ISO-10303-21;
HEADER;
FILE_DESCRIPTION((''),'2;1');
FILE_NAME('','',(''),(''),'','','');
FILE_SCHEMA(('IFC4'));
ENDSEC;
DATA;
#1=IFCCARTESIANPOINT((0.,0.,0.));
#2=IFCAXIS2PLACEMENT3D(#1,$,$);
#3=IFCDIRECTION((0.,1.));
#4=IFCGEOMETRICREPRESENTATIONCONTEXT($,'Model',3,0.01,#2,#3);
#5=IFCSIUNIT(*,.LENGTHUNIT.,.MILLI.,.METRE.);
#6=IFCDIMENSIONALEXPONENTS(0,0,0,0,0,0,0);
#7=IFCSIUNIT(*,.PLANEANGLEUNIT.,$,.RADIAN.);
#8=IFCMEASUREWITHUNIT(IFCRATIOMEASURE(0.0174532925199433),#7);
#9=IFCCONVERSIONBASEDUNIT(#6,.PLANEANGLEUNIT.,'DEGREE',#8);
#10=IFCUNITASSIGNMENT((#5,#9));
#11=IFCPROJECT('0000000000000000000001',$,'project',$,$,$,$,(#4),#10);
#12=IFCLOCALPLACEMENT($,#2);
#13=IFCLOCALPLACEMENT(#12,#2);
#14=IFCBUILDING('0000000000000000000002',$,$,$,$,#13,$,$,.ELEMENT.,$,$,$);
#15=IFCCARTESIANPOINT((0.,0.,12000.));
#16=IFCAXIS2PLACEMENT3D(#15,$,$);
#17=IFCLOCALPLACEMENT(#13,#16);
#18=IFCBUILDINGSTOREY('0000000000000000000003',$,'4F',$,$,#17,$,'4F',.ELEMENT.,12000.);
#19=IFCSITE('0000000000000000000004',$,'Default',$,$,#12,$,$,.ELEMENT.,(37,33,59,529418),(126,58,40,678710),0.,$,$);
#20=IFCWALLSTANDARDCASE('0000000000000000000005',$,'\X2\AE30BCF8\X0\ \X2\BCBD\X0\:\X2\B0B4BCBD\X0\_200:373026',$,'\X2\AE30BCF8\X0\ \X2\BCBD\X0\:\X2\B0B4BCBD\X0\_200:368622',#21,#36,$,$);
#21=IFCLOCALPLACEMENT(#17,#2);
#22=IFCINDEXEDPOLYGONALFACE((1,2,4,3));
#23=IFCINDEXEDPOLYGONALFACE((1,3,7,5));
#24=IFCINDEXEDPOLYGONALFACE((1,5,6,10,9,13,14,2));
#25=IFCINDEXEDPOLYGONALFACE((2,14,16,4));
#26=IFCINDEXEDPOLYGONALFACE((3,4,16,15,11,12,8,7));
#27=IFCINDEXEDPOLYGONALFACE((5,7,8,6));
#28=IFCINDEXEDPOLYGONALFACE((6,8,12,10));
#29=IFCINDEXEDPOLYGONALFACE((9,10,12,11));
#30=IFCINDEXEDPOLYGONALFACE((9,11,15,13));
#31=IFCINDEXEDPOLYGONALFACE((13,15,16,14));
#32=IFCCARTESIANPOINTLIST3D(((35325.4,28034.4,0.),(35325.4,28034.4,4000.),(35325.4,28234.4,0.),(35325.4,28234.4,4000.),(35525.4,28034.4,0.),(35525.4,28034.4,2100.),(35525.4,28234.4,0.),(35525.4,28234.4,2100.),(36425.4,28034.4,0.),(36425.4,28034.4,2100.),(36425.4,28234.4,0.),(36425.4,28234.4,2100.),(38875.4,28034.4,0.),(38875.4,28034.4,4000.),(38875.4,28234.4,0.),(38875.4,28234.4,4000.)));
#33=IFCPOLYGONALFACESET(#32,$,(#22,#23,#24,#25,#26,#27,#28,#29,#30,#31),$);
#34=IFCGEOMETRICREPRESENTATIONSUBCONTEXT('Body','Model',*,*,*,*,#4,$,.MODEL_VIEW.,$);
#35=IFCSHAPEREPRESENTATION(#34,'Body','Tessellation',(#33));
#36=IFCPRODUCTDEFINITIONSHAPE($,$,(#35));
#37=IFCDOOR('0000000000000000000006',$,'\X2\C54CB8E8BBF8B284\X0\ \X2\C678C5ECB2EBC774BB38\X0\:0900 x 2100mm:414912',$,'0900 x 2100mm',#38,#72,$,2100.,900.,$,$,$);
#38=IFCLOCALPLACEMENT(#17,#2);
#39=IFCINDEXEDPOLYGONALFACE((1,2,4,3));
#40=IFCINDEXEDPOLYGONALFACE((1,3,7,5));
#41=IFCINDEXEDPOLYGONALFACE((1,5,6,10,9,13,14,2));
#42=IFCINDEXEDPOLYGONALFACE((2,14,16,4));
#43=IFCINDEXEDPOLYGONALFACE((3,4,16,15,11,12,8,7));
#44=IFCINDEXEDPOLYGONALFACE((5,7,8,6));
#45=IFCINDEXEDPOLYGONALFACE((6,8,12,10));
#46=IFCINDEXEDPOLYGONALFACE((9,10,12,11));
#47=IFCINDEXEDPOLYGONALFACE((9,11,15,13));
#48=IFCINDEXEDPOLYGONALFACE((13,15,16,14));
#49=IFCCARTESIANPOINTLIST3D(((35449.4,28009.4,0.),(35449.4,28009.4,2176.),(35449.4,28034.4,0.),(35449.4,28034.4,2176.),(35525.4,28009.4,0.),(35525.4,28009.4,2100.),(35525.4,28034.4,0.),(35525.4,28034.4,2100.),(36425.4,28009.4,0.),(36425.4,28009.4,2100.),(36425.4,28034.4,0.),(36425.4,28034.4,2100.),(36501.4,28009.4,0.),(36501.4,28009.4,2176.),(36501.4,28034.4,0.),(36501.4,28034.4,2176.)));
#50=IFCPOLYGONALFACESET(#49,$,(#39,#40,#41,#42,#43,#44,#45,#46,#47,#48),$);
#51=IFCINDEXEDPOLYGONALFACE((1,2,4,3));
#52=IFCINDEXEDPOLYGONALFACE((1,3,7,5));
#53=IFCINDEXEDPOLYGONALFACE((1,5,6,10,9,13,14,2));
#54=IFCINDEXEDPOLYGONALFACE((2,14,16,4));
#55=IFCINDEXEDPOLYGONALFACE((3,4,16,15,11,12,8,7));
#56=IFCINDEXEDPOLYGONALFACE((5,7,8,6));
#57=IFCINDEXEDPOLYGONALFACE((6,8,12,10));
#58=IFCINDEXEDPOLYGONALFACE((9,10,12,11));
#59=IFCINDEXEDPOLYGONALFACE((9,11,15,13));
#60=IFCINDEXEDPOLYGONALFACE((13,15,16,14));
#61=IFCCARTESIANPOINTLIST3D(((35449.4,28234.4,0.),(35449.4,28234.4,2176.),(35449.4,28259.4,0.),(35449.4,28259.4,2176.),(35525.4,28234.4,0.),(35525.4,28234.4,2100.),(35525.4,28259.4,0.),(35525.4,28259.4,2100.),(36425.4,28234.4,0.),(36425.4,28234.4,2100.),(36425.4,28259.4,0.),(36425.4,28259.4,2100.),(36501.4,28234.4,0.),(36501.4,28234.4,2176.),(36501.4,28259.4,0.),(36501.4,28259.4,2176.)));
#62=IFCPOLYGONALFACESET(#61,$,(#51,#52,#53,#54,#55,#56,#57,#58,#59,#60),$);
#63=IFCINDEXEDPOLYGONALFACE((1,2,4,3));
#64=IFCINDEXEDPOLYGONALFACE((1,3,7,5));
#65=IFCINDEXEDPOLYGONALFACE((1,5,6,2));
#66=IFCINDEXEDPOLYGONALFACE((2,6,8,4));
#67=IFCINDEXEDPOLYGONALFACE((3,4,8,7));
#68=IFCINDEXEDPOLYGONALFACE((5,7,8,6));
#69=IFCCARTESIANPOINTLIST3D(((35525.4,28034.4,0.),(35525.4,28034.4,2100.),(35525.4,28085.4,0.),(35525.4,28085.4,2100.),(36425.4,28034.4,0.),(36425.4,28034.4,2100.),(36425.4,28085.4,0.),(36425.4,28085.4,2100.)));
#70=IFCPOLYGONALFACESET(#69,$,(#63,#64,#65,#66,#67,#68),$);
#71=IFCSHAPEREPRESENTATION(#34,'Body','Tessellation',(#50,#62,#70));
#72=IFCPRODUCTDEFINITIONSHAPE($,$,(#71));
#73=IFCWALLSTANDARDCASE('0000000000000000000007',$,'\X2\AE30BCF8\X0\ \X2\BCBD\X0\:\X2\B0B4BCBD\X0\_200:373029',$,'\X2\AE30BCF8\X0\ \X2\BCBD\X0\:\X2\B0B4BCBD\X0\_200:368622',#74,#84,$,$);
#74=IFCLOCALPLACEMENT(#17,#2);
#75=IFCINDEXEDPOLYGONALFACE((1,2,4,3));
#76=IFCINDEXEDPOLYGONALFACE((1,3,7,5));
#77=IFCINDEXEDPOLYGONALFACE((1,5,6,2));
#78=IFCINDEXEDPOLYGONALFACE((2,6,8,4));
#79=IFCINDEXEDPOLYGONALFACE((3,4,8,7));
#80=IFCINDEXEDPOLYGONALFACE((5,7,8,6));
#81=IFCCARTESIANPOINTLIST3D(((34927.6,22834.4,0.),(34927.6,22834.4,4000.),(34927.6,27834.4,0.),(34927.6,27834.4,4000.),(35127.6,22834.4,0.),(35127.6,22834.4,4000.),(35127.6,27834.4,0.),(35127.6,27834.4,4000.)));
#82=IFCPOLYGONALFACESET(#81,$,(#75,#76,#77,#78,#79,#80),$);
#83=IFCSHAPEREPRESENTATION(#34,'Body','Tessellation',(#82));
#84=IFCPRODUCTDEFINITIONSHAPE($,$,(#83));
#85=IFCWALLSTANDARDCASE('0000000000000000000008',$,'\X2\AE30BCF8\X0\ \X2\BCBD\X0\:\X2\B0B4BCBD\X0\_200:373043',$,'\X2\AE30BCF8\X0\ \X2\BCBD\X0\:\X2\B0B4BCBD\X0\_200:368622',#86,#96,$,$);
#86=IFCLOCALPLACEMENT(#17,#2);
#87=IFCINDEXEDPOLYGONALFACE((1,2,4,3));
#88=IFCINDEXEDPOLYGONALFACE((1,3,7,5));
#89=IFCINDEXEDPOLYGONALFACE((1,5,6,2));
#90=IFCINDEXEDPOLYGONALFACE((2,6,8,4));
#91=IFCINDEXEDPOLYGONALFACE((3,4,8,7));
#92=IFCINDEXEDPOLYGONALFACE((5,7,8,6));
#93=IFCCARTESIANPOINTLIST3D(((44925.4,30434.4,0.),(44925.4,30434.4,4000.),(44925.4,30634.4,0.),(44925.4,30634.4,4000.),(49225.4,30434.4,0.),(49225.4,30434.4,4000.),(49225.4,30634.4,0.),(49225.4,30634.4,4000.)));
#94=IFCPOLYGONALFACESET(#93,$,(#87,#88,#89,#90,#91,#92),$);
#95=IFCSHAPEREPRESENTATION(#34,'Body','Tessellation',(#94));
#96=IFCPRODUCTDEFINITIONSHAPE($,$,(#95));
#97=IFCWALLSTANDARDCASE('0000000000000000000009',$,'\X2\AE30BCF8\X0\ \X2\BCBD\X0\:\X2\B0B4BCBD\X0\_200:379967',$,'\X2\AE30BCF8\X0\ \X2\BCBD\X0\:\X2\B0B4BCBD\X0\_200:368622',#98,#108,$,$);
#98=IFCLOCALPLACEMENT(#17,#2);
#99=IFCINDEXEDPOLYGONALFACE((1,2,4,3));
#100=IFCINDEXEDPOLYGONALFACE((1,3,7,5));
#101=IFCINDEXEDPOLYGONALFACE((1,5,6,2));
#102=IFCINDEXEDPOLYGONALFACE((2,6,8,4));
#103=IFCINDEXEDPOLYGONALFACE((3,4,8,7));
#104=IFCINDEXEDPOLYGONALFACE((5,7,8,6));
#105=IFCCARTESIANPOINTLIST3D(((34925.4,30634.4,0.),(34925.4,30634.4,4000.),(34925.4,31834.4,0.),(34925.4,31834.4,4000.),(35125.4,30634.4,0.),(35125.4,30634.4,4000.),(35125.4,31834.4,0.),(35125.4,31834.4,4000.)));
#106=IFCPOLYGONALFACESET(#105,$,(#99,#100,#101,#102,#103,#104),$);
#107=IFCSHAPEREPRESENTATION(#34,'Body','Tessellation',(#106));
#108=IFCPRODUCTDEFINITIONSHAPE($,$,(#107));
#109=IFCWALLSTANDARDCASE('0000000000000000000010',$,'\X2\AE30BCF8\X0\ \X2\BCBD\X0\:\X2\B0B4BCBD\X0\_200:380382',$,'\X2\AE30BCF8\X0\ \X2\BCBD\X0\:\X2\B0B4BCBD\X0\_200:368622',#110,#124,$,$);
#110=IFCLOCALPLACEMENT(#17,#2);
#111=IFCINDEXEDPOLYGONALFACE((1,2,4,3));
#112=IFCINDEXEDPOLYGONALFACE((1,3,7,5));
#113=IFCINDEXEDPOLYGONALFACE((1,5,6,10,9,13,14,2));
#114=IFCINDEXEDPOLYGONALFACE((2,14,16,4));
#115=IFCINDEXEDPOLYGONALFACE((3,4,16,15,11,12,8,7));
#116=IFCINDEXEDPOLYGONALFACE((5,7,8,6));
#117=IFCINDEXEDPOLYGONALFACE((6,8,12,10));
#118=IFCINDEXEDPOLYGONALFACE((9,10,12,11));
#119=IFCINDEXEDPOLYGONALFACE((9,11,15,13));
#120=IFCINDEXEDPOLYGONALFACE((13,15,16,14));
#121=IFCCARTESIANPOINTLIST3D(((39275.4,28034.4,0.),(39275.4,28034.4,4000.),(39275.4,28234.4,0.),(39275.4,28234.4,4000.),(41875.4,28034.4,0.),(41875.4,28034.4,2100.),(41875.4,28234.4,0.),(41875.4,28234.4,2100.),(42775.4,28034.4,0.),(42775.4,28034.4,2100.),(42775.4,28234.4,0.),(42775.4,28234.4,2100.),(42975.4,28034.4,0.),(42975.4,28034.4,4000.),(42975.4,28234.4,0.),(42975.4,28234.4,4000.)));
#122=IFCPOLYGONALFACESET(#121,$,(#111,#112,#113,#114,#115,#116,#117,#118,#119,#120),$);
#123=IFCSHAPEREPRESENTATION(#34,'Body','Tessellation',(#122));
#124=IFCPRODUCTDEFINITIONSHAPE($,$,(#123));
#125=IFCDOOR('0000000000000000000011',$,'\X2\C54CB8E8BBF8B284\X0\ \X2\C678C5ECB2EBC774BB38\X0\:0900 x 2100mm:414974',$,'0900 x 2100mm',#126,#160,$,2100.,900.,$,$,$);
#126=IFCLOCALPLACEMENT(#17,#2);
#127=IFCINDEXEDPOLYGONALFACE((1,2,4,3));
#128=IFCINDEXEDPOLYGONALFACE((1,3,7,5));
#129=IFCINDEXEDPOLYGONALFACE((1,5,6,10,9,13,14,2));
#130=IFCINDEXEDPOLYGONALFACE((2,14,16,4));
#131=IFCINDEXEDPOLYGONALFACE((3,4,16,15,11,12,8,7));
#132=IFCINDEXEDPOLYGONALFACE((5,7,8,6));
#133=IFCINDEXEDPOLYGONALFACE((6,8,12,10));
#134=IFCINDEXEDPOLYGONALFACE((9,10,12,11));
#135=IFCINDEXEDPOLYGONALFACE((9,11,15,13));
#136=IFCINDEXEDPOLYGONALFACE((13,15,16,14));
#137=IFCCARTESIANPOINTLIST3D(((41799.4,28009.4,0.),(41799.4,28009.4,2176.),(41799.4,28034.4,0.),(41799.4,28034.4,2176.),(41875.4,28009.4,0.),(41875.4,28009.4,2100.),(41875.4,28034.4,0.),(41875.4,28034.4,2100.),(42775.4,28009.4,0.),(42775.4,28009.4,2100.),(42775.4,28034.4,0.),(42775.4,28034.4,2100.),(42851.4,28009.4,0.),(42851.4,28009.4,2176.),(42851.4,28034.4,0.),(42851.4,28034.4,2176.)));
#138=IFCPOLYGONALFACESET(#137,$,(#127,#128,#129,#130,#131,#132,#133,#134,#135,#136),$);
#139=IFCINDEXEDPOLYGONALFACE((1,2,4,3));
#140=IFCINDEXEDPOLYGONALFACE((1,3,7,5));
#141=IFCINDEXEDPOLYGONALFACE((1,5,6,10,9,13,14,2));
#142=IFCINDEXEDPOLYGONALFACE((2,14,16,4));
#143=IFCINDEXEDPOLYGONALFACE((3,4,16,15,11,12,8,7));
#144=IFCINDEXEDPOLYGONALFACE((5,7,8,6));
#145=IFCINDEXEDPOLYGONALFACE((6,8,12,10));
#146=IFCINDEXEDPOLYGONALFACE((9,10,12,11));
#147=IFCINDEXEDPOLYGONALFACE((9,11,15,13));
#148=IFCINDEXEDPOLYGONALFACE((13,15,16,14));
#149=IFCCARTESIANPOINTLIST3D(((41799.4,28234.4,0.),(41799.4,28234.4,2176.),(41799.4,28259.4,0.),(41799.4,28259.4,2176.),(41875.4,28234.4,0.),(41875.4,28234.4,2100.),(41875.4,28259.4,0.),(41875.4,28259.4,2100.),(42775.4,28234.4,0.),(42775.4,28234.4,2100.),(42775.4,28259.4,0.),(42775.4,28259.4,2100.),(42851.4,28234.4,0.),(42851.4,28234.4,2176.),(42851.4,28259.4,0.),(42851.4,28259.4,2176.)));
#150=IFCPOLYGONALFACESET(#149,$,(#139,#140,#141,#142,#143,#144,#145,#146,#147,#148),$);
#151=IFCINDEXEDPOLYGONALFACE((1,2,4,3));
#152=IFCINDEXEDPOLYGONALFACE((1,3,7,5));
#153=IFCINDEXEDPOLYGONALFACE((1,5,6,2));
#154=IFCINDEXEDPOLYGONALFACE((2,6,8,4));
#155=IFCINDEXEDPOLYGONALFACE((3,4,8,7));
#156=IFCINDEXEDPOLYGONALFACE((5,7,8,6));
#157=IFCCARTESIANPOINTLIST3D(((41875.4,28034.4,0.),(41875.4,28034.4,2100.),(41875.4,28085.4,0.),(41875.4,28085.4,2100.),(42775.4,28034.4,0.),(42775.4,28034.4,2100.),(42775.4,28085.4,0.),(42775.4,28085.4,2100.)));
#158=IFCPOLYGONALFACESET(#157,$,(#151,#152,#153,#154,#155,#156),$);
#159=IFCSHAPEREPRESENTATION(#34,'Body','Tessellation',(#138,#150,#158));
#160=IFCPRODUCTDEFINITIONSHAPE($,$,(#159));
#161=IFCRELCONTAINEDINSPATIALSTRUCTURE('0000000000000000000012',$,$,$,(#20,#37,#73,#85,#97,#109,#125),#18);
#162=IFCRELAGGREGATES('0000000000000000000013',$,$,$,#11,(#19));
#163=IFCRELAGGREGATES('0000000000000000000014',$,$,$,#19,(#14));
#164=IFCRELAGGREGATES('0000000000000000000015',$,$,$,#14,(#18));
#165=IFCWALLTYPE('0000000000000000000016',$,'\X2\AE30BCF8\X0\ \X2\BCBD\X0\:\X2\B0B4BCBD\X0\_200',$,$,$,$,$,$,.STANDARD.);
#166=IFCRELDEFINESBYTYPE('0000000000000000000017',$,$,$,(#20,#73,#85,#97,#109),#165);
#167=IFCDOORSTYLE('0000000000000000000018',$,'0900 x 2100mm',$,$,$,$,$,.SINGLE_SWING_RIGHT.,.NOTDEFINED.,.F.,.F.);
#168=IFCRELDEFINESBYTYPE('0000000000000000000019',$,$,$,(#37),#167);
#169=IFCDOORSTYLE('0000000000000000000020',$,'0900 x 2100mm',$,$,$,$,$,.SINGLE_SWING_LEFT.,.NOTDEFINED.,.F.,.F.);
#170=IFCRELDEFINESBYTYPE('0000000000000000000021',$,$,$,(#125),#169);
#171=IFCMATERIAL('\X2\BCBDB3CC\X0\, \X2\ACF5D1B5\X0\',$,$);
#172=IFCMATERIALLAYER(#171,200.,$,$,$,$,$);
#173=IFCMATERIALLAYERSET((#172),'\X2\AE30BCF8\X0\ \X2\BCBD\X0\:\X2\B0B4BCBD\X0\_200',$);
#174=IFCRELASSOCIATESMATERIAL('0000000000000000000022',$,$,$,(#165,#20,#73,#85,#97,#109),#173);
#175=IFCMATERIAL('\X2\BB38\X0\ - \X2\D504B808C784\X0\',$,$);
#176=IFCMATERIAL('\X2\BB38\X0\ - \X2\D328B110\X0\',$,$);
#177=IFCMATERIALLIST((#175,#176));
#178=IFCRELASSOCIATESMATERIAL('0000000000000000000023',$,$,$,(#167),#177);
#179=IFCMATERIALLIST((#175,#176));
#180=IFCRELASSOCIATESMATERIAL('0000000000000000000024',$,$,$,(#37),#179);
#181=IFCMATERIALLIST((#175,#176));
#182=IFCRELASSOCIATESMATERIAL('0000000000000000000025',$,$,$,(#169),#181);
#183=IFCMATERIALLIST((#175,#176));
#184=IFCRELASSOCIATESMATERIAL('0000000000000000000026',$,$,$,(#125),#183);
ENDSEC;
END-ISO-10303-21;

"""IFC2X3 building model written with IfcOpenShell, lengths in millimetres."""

from ifc_helpers import new_model, entity, si_unit, converted_unit, direction, frame, frame_2d, origin, place, context, subcontext, project, spatial, polyline, rectangle, outline, extrude, source, transform, mapped, material, material_list, layer, layer_set, layer_usage, type_object, type_shapes, element, fill, save


model = new_model("IFC2X3")

# Units and contexts
model_context = context("Model", 3, precision=0.01, world=origin(), true_north=direction((0.0, 1.0)))
body_context = subcontext(model_context, "Body", "Model", "MODEL_VIEW")
ifc_project = project(units=[si_unit("LENGTHUNIT", "METRE", prefix="MILLI"), converted_unit("PLANEANGLEUNIT", "DEGREE", entity("IfcRatioMeasure", 0.0174532925199433), si_unit("PLANEANGLEUNIT", "RADIAN"), dimensions=[0, 0, 0, 0, 0, 0, 0])], contexts=[model_context])

# Site, building, storey
site_placement = place(None, origin())
site = spatial("IfcSite", under=ifc_project, at=site_placement, Name="Default", CompositionType="ELEMENT", RefLatitude=(37, 33, 59, 529418), RefLongitude=(126, 58, 40, 678710), RefElevation=0.0)
building_placement = place(site_placement, origin())
building = spatial("IfcBuilding", under=site, at=building_placement, CompositionType="ELEMENT")
storey_placement = place(building_placement, frame((0.0, 0.0, 12000.0)))
storey = spatial("IfcBuildingStorey", under=building, at=storey_placement, Name="4F", LongName="4F", CompositionType="ELEMENT", Elevation=12000.0)

# Wall, opening, door
ifc_material_1 = material(Name="벽돌, 공통")
ifc_layer_1 = layer(ifc_material_1, 200.0)
ifc_layer_set_1 = layer_set([ifc_layer_1], Name="기본 벽:내벽_200")
ifc_layer_usage_1 = layer_usage(ifc_layer_set_1, "AXIS2", "NEGATIVE", 100.0)
wall_type_1 = type_object("IfcWallType", Name="기본 벽:내벽_200", PredefinedType="STANDARD", material=ifc_layer_set_1)
wall_1_placement = place(storey_placement, frame((35325.4, 28134.4, 0.0)))
wall_1 = element("IfcWallStandardCase", 1, at=wall_1_placement, inside=storey, type_object=wall_type_1, material=ifc_layer_usage_1, Name="기본 벽:내벽_200:373026", ObjectType="기본 벽:내벽_200:368622", context=body_context, shape_type="SweptSolid", body=[
    extrude(rectangle(XDim=3550.0, YDim=200.0, at=frame_2d((1775.0, 0.0), x_axis=(-1.0, 0.0))), origin(), (0.0, 0.0, 1.0), 4000.0),
])
opening_1_placement = place(wall_1_placement, frame((1100.0, 100.0, 0.0)))
opening_1 = element("IfcOpeningElement", 2, at=opening_1_placement, cuts=wall_1, ObjectType="Opening", context=body_context, shape_type="SweptSolid", body=[
    extrude(rectangle(XDim=900.0, YDim=2100.0, at=frame_2d((1050.0, 450.0), x_axis=(0.0, 1.0))), frame((0.0, 0.0, 0.0), z_axis=(0.0, -1.0, 0.0), x_axis=(0.0, 0.0, 1.0)), (0.0, 0.0, 1.0), 200.0),
])
ifc_material_2 = material(Name="문 - 프레임")
ifc_material_3 = material(Name="문 - 패널")
ifc_material_list_1 = material_list([ifc_material_2, ifc_material_3])
ifc_material_list_2 = material_list([ifc_material_2, ifc_material_3])
door_style_1 = type_object("IfcDoorStyle", Name="0900 x 2100mm", ConstructionType="NOTDEFINED", OperationType="SINGLE_SWING_RIGHT", ParameterTakesPrecedence=False, Sizeable=False, material=ifc_material_list_2)
shared_shape_1 = source(origin(), body_context, "Body", "SweptSolid", [
    extrude(outline(polyline([(-526.0, -1107.0), (526.0, -1107.0), (526.0, 1069.0), (450.0, 1069.0), (450.0, -1031.0), (-450.0, -1031.0), (-450.0, 1069.0), (-526.0, 1069.0), (-526.0, -1107.0)])), frame((450.0, 200.0, 1069.0), z_axis=(0.0, 1.0, 0.0), x_axis=(1.0, 0.0, 0.0)), (0.0, 0.0, 1.0), 25.0),
    extrude(outline(polyline([(-1107.0, -526.0), (1069.0, -526.0), (1069.0, -450.0), (-1031.0, -450.0), (-1031.0, 450.0), (1069.0, 450.0), (1069.0, 526.0), (-1107.0, 526.0), (-1107.0, -526.0)])), frame((450.0, -25.0, 1069.0), z_axis=(0.0, 1.0, 0.0), x_axis=(0.0, 0.0, -1.0)), (0.0, 0.0, 1.0), 25.0),
    extrude(rectangle(XDim=51.0, YDim=900.0, at=frame_2d((0.0, 0.0), x_axis=(1.0, 0.0))), frame((450.0, 174.5, 0.0), z_axis=(0.0, 0.0, 1.0), x_axis=(0.0, 1.0, 0.0)), (0.0, 0.0, 1.0), 2100.0),
])
type_shapes(door_style_1, [shared_shape_1])
door_1_placement = place(opening_1_placement, frame((0.0, 0.0, 0.0), z_axis=(0.0, 0.0, 1.0), x_axis=(-1.0, 0.0, 0.0)))
door_1 = element("IfcDoor", 3, at=door_1_placement, inside=storey, type_object=door_style_1, material=ifc_material_list_1, Name="알루미늄 외여닫이문:0900 x 2100mm:414912", ObjectType="0900 x 2100mm", OverallHeight=2100.0, OverallWidth=900.0, context=body_context, shape_type="MappedRepresentation", body=[
    mapped(shared_shape_1, transform((0.0, 0.0, 0.0), scale=1.0)),
])
fill(opening_1, door_1)

# Walls
ifc_layer_usage_2 = layer_usage(ifc_layer_set_1, "AXIS2", "NEGATIVE", 100.0)
wall_2_placement = place(storey_placement, frame((35027.6, 22834.4, 0.0), z_axis=(0.0, 0.0, 1.0), x_axis=(0.0, 1.0, 0.0)))
element("IfcWallStandardCase", 4, at=wall_2_placement, inside=storey, type_object=wall_type_1, material=ifc_layer_usage_2, Name="기본 벽:내벽_200:373029", ObjectType="기본 벽:내벽_200:368622", context=body_context, shape_type="SweptSolid", body=[
    extrude(rectangle(XDim=5000.0, YDim=200.0, at=frame_2d((2500.0, 0.0), x_axis=(-1.0, 0.0))), origin(), (0.0, 0.0, 1.0), 4000.0),
])
ifc_layer_usage_3 = layer_usage(ifc_layer_set_1, "AXIS2", "NEGATIVE", 100.0)
wall_3_placement = place(storey_placement, frame((44925.4, 30534.4, 0.0)))
element("IfcWallStandardCase", 5, at=wall_3_placement, inside=storey, type_object=wall_type_1, material=ifc_layer_usage_3, Name="기본 벽:내벽_200:373043", ObjectType="기본 벽:내벽_200:368622", context=body_context, shape_type="SweptSolid", body=[
    extrude(rectangle(XDim=4300.0, YDim=200.0, at=frame_2d((2150.0, 0.0), x_axis=(-1.0, 0.0))), origin(), (0.0, 0.0, 1.0), 4000.0),
])
ifc_layer_usage_4 = layer_usage(ifc_layer_set_1, "AXIS2", "NEGATIVE", 100.0)
wall_4_placement = place(storey_placement, frame((35025.4, 30634.4, 0.0), z_axis=(0.0, 0.0, 1.0), x_axis=(0.0, 1.0, 0.0)))
element("IfcWallStandardCase", 6, at=wall_4_placement, inside=storey, type_object=wall_type_1, material=ifc_layer_usage_4, Name="기본 벽:내벽_200:379967", ObjectType="기본 벽:내벽_200:368622", context=body_context, shape_type="SweptSolid", body=[
    extrude(rectangle(XDim=1200.0, YDim=200.0, at=frame_2d((600.0, 0.0), x_axis=(-1.0, 0.0))), origin(), (0.0, 0.0, 1.0), 4000.0),
])

# Wall, opening, door
ifc_layer_usage_5 = layer_usage(ifc_layer_set_1, "AXIS2", "NEGATIVE", 100.0)
wall_5_placement = place(storey_placement, frame((39275.4, 28134.4, 0.0)))
wall_5 = element("IfcWallStandardCase", 7, at=wall_5_placement, inside=storey, type_object=wall_type_1, material=ifc_layer_usage_5, Name="기본 벽:내벽_200:380382", ObjectType="기본 벽:내벽_200:368622", context=body_context, shape_type="SweptSolid", body=[
    extrude(rectangle(XDim=3700.0, YDim=200.0, at=frame_2d((1850.0, 0.0), x_axis=(-1.0, 0.0))), origin(), (0.0, 0.0, 1.0), 4000.0),
])
opening_2_placement = place(wall_5_placement, frame((3500.0, 100.0, 0.0)))
opening_2 = element("IfcOpeningElement", 8, at=opening_2_placement, cuts=wall_5, ObjectType="Opening", context=body_context, shape_type="SweptSolid", body=[
    extrude(rectangle(XDim=900.0, YDim=2100.0, at=frame_2d((1050.0, 450.0), x_axis=(0.0, -1.0))), frame((0.0, 0.0, 0.0), z_axis=(0.0, -1.0, 0.0), x_axis=(0.0, 0.0, 1.0)), (0.0, 0.0, 1.0), 200.0),
])
ifc_material_list_3 = material_list([ifc_material_2, ifc_material_3])
ifc_material_list_4 = material_list([ifc_material_2, ifc_material_3])
door_style_2 = type_object("IfcDoorStyle", Name="0900 x 2100mm", ConstructionType="NOTDEFINED", OperationType="SINGLE_SWING_LEFT", ParameterTakesPrecedence=False, Sizeable=False, material=ifc_material_list_4)
shared_shape_2 = source(origin(), body_context, "Body", "SweptSolid", [
    extrude(outline(polyline([(-526.0, -1107.0), (526.0, -1107.0), (526.0, 1069.0), (450.0, 1069.0), (450.0, -1031.0), (-450.0, -1031.0), (-450.0, 1069.0), (-526.0, 1069.0), (-526.0, -1107.0)])), frame((450.0, 225.0, 1069.0), z_axis=(0.0, -1.0, 0.0), x_axis=(-1.0, 0.0, 0.0)), (0.0, 0.0, 1.0), 25.0),
    extrude(outline(polyline([(-1107.0, -526.0), (1069.0, -526.0), (1069.0, -450.0), (-1031.0, -450.0), (-1031.0, 450.0), (1069.0, 450.0), (1069.0, 526.0), (-1107.0, 526.0), (-1107.0, -526.0)])), frame((450.0, 0.0, 1069.0), z_axis=(0.0, -1.0, 0.0), x_axis=(0.0, 0.0, -1.0)), (0.0, 0.0, 1.0), 25.0),
    extrude(rectangle(XDim=900.0, YDim=51.0, at=frame_2d((0.0, 0.0), x_axis=(1.0, 0.0))), frame((450.0, 174.5, 0.0)), (0.0, 0.0, 1.0), 2100.0),
])
type_shapes(door_style_2, [shared_shape_2])
door_2_placement = place(opening_2_placement, frame((0.0, 0.0, 0.0), z_axis=(0.0, 0.0, 1.0), x_axis=(-1.0, 0.0, 0.0)))
door_2 = element("IfcDoor", 9, at=door_2_placement, inside=storey, type_object=door_style_2, material=ifc_material_list_3, Name="알루미늄 외여닫이문:0900 x 2100mm:414974", ObjectType="0900 x 2100mm", OverallHeight=2100.0, OverallWidth=900.0, context=body_context, shape_type="MappedRepresentation", body=[
    mapped(shared_shape_2, transform((0.0, 0.0, 0.0), scale=1.0)),
])
fill(opening_2, door_2)

save(model, "model.ifc")
